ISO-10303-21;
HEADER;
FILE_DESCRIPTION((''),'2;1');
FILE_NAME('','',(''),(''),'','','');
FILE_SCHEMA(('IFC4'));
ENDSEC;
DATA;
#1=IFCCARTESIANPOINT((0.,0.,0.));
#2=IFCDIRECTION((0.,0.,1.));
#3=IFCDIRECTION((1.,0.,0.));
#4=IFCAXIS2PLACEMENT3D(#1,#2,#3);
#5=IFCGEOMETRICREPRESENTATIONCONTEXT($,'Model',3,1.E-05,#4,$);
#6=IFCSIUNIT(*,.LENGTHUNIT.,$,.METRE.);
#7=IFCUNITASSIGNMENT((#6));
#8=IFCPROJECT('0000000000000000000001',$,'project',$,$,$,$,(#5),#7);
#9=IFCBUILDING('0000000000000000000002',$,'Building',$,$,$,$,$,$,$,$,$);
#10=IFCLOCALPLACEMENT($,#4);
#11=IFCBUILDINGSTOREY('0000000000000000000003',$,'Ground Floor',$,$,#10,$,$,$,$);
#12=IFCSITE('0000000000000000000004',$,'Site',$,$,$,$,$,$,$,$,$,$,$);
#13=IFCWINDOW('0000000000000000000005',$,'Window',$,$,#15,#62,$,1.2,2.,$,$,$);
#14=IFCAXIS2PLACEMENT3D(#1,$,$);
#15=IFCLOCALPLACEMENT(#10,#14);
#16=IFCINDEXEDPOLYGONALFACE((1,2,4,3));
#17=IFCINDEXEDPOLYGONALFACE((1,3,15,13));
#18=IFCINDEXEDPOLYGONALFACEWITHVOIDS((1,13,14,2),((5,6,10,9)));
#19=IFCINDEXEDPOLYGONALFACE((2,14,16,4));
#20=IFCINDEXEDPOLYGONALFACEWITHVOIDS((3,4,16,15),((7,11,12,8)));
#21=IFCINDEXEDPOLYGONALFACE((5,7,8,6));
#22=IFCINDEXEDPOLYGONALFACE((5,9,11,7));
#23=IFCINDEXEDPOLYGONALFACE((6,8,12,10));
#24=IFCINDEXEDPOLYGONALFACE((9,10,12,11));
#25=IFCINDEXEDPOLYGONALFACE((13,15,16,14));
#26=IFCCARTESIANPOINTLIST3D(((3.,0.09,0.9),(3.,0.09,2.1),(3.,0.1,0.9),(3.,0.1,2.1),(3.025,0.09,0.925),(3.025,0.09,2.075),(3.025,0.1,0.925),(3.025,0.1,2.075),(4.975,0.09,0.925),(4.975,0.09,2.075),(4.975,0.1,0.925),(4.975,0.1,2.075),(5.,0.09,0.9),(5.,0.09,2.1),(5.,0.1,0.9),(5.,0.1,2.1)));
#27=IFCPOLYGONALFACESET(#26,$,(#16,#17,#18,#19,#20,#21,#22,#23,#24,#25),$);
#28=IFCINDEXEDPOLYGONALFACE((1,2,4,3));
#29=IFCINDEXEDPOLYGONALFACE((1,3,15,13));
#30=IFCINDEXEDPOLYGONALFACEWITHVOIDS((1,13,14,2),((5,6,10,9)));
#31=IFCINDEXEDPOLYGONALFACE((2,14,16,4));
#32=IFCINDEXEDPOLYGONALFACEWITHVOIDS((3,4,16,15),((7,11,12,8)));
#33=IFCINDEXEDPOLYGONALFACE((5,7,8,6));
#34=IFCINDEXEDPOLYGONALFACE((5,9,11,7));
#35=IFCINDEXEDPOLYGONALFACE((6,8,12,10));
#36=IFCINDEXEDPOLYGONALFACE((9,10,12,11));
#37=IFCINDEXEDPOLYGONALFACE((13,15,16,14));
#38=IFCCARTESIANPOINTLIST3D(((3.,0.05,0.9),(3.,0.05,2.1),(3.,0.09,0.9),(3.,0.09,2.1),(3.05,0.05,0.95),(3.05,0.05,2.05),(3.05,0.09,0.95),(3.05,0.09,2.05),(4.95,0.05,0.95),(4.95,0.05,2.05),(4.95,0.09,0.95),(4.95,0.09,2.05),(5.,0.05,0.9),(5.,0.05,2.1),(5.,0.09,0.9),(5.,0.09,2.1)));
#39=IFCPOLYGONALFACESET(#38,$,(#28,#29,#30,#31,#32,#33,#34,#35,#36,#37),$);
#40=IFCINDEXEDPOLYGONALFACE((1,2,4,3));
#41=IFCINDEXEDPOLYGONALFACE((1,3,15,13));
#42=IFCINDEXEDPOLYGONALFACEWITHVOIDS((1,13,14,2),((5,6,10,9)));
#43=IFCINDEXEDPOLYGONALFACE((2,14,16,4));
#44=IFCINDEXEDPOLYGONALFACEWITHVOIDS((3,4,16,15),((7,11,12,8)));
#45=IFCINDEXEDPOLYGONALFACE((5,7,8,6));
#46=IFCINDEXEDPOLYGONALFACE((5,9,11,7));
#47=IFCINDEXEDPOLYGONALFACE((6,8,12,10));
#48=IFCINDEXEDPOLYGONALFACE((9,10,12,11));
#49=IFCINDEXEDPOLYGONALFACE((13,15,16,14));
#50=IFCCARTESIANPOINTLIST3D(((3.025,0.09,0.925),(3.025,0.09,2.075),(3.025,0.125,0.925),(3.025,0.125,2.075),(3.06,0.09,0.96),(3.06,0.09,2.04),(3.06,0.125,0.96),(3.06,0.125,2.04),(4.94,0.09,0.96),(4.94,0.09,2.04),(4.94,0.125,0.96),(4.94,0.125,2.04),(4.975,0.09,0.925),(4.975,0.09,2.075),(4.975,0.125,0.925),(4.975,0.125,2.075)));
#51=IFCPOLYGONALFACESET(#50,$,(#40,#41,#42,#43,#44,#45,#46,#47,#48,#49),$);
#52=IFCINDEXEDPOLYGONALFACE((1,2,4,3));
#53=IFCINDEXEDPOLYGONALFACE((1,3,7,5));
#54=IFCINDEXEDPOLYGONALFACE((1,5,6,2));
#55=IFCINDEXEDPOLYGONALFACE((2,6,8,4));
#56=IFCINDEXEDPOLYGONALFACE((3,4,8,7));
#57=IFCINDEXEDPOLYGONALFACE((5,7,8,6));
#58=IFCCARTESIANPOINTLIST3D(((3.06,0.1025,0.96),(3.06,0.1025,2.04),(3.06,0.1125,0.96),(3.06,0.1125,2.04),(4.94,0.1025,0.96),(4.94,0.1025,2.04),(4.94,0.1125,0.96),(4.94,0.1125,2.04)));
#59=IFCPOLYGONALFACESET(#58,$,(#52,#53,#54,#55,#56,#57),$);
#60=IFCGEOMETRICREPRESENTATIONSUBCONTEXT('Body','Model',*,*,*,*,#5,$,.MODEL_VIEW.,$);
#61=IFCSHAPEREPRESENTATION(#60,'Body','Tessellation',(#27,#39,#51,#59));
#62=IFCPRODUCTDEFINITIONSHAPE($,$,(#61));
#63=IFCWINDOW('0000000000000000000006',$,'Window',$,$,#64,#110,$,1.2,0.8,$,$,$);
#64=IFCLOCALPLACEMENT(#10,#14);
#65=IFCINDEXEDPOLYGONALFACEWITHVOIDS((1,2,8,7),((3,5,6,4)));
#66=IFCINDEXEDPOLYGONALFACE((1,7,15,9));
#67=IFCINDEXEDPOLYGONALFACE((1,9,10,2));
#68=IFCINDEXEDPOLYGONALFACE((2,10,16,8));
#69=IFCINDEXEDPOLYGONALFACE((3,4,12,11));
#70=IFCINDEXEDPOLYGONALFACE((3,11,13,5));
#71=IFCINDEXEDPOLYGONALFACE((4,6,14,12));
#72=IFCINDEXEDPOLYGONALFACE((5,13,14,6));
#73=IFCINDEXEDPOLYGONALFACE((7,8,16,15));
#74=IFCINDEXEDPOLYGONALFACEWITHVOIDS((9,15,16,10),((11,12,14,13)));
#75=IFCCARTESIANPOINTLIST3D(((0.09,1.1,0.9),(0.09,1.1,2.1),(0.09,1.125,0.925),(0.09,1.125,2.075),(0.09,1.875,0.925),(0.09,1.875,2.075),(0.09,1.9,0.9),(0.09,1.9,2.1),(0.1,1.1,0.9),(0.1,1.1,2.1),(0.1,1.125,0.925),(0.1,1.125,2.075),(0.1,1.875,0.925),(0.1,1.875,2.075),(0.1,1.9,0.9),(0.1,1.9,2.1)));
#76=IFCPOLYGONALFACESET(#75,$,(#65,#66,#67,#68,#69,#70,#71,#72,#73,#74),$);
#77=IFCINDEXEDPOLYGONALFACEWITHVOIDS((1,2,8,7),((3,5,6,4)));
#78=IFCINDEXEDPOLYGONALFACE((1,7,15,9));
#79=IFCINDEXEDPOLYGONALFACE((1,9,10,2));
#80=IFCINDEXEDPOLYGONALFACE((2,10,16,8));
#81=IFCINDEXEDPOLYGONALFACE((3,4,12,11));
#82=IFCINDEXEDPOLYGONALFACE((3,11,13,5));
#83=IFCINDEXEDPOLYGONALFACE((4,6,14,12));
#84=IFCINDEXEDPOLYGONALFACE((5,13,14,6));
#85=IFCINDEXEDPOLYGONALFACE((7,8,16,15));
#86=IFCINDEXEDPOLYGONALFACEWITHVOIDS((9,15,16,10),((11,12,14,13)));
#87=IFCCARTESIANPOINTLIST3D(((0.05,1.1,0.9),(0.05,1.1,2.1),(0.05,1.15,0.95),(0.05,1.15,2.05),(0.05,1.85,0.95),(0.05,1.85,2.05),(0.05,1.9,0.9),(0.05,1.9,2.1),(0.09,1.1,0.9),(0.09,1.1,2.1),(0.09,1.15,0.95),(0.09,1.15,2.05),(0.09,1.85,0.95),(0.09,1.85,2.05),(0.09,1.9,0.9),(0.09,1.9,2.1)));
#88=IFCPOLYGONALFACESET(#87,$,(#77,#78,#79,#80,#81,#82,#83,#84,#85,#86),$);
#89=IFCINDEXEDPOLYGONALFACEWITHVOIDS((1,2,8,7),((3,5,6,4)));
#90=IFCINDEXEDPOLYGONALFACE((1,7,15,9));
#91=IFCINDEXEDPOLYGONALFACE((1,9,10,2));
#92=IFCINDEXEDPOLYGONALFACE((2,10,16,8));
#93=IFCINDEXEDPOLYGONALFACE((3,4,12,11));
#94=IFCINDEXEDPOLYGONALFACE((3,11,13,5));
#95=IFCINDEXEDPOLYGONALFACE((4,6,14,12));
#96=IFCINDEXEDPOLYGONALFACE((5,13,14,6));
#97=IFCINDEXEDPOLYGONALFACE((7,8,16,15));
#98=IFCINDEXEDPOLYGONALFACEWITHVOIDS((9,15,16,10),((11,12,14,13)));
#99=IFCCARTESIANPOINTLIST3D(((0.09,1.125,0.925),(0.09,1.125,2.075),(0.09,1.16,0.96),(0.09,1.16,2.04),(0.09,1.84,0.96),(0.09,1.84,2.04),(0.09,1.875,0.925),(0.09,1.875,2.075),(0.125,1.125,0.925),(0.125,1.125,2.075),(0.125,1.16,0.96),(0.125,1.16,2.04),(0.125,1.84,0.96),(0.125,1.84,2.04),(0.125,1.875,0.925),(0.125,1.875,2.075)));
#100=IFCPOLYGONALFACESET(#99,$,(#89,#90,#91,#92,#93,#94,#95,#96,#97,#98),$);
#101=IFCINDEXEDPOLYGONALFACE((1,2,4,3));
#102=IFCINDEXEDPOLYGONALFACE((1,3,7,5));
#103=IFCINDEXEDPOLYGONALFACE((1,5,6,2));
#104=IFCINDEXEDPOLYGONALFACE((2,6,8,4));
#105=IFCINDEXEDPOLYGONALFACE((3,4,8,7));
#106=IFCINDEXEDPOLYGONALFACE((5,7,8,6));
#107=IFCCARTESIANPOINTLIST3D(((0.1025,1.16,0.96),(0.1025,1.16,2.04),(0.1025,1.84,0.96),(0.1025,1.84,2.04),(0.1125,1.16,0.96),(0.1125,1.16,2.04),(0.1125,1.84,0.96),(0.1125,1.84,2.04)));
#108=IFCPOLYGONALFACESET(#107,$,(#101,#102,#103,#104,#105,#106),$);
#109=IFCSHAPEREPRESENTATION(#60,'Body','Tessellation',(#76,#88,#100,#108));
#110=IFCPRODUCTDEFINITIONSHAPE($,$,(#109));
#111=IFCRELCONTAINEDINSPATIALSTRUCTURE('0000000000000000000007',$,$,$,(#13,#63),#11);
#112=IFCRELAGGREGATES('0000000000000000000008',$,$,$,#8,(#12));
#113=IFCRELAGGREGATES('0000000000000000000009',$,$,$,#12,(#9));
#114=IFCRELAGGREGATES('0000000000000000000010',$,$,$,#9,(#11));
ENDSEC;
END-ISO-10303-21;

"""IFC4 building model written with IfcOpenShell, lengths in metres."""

from ifc_helpers import new_model, si_unit, frame, origin_with_axes, place, context, subcontext, project, spatial, line, indexed_curve, outline, extrude, element, save


model = new_model("IFC4")

# Units and contexts
model_context = context("Model", 3, precision=1e-05, world=origin_with_axes())
body_context = subcontext(model_context, "Body", "Model", "MODEL_VIEW")
ifc_project = project(units=[si_unit("LENGTHUNIT", "METRE")], contexts=[model_context])

# Site, building, storey
site = spatial("IfcSite", under=ifc_project, Name="Site")
building = spatial("IfcBuilding", under=site, Name="Building")
storey_placement = place(None, origin_with_axes())
storey = spatial("IfcBuildingStorey", under=building, at=storey_placement, Name="Ground Floor")

# Windows
window_1_placement = place(storey_placement, frame((3.0, 0.0, 0.9), z_axis=(0.0, 0.0, 1.0), x_axis=(1.0, 0.0, 0.0)))
element("IfcWindow", 1, at=window_1_placement, inside=storey, Name="Window", OverallHeight=1.2, OverallWidth=2.0, context=body_context, shape_type="SweptSolid", body=[
    extrude(outline(indexed_curve([(0.0, 0.0), (2.0, 0.0), (2.0, 1.2), (0.0, 1.2)], segments=[line(1, 2, 3, 4, 1)]), holes=[indexed_curve([(0.025, 0.025), (1.975, 0.025), (1.975, 1.175), (0.025, 1.175)], segments=[line(1, 2, 3, 4, 1)])]), frame((0.0, 0.09, 0.0), z_axis=(0.0, -1.0, 0.0), x_axis=(1.0, 0.0, 0.0)), (0.0, 0.0, -1.0), 0.01),
    extrude(outline(indexed_curve([(0.0, 0.0), (2.0, 0.0), (2.0, 1.2), (0.0, 1.2)], segments=[line(1, 2, 3, 4, 1)]), holes=[indexed_curve([(0.05, 0.05), (1.95, 0.05), (1.95, 1.15), (0.05, 1.15)], segments=[line(1, 2, 3, 4, 1)])]), frame((0.0, 0.05, 0.0), z_axis=(0.0, -1.0, 0.0), x_axis=(1.0, 0.0, 0.0)), (0.0, 0.0, -1.0), 0.04),
    extrude(outline(indexed_curve([(0.0, 0.0), (1.95, 0.0), (1.95, 1.15), (0.0, 1.15)], segments=[line(1, 2, 3, 4, 1)]), holes=[indexed_curve([(0.035, 0.035), (1.915, 0.035), (1.915, 1.115), (0.035, 1.115)], segments=[line(1, 2, 3, 4, 1)])]), frame((0.025, 0.09, 0.025), z_axis=(0.0, -1.0, 0.0), x_axis=(1.0, 0.0, 0.0)), (0.0, 0.0, -1.0), 0.035),
    extrude(outline(indexed_curve([(0.035, 0.035), (1.915, 0.035), (1.915, 1.115), (0.035, 1.115)], segments=[line(1, 2, 3, 4, 1)])), frame((0.025, 0.1025, 0.025), z_axis=(0.0, -1.0, 0.0), x_axis=(1.0, 0.0, 0.0)), (0.0, 0.0, -1.0), 0.01),
])
window_2_placement = place(storey_placement, frame((0.0, 1.9, 0.9), z_axis=(0.0, 0.0, 1.0), x_axis=(0.0, -1.0, 0.0)))
element("IfcWindow", 2, at=window_2_placement, inside=storey, Name="Window", OverallHeight=1.2, OverallWidth=0.8, context=body_context, shape_type="SweptSolid", body=[
    extrude(outline(indexed_curve([(0.0, 0.0), (0.8, 0.0), (0.8, 1.2), (0.0, 1.2)], segments=[line(1, 2, 3, 4, 1)]), holes=[indexed_curve([(0.025, 0.025), (0.775, 0.025), (0.775, 1.175), (0.025, 1.175)], segments=[line(1, 2, 3, 4, 1)])]), frame((0.0, 0.09, 0.0), z_axis=(0.0, -1.0, 0.0), x_axis=(1.0, 0.0, 0.0)), (0.0, 0.0, -1.0), 0.01),
    extrude(outline(indexed_curve([(0.0, 0.0), (0.8, 0.0), (0.8, 1.2), (0.0, 1.2)], segments=[line(1, 2, 3, 4, 1)]), holes=[indexed_curve([(0.05, 0.05), (0.75, 0.05), (0.75, 1.15), (0.05, 1.15)], segments=[line(1, 2, 3, 4, 1)])]), frame((0.0, 0.05, 0.0), z_axis=(0.0, -1.0, 0.0), x_axis=(1.0, 0.0, 0.0)), (0.0, 0.0, -1.0), 0.04),
    extrude(outline(indexed_curve([(0.0, 0.0), (0.75, 0.0), (0.75, 1.15), (0.0, 1.15)], segments=[line(1, 2, 3, 4, 1)]), holes=[indexed_curve([(0.035, 0.035), (0.715, 0.035), (0.715, 1.115), (0.035, 1.115)], segments=[line(1, 2, 3, 4, 1)])]), frame((0.025, 0.09, 0.025), z_axis=(0.0, -1.0, 0.0), x_axis=(1.0, 0.0, 0.0)), (0.0, 0.0, -1.0), 0.035),
    extrude(outline(indexed_curve([(0.035, 0.035), (0.715, 0.035), (0.715, 1.115), (0.035, 1.115)], segments=[line(1, 2, 3, 4, 1)])), frame((0.025, 0.1025, 0.025), z_axis=(0.0, -1.0, 0.0), x_axis=(1.0, 0.0, 0.0)), (0.0, 0.0, -1.0), 0.01),
])

save(model, "model.ifc")
